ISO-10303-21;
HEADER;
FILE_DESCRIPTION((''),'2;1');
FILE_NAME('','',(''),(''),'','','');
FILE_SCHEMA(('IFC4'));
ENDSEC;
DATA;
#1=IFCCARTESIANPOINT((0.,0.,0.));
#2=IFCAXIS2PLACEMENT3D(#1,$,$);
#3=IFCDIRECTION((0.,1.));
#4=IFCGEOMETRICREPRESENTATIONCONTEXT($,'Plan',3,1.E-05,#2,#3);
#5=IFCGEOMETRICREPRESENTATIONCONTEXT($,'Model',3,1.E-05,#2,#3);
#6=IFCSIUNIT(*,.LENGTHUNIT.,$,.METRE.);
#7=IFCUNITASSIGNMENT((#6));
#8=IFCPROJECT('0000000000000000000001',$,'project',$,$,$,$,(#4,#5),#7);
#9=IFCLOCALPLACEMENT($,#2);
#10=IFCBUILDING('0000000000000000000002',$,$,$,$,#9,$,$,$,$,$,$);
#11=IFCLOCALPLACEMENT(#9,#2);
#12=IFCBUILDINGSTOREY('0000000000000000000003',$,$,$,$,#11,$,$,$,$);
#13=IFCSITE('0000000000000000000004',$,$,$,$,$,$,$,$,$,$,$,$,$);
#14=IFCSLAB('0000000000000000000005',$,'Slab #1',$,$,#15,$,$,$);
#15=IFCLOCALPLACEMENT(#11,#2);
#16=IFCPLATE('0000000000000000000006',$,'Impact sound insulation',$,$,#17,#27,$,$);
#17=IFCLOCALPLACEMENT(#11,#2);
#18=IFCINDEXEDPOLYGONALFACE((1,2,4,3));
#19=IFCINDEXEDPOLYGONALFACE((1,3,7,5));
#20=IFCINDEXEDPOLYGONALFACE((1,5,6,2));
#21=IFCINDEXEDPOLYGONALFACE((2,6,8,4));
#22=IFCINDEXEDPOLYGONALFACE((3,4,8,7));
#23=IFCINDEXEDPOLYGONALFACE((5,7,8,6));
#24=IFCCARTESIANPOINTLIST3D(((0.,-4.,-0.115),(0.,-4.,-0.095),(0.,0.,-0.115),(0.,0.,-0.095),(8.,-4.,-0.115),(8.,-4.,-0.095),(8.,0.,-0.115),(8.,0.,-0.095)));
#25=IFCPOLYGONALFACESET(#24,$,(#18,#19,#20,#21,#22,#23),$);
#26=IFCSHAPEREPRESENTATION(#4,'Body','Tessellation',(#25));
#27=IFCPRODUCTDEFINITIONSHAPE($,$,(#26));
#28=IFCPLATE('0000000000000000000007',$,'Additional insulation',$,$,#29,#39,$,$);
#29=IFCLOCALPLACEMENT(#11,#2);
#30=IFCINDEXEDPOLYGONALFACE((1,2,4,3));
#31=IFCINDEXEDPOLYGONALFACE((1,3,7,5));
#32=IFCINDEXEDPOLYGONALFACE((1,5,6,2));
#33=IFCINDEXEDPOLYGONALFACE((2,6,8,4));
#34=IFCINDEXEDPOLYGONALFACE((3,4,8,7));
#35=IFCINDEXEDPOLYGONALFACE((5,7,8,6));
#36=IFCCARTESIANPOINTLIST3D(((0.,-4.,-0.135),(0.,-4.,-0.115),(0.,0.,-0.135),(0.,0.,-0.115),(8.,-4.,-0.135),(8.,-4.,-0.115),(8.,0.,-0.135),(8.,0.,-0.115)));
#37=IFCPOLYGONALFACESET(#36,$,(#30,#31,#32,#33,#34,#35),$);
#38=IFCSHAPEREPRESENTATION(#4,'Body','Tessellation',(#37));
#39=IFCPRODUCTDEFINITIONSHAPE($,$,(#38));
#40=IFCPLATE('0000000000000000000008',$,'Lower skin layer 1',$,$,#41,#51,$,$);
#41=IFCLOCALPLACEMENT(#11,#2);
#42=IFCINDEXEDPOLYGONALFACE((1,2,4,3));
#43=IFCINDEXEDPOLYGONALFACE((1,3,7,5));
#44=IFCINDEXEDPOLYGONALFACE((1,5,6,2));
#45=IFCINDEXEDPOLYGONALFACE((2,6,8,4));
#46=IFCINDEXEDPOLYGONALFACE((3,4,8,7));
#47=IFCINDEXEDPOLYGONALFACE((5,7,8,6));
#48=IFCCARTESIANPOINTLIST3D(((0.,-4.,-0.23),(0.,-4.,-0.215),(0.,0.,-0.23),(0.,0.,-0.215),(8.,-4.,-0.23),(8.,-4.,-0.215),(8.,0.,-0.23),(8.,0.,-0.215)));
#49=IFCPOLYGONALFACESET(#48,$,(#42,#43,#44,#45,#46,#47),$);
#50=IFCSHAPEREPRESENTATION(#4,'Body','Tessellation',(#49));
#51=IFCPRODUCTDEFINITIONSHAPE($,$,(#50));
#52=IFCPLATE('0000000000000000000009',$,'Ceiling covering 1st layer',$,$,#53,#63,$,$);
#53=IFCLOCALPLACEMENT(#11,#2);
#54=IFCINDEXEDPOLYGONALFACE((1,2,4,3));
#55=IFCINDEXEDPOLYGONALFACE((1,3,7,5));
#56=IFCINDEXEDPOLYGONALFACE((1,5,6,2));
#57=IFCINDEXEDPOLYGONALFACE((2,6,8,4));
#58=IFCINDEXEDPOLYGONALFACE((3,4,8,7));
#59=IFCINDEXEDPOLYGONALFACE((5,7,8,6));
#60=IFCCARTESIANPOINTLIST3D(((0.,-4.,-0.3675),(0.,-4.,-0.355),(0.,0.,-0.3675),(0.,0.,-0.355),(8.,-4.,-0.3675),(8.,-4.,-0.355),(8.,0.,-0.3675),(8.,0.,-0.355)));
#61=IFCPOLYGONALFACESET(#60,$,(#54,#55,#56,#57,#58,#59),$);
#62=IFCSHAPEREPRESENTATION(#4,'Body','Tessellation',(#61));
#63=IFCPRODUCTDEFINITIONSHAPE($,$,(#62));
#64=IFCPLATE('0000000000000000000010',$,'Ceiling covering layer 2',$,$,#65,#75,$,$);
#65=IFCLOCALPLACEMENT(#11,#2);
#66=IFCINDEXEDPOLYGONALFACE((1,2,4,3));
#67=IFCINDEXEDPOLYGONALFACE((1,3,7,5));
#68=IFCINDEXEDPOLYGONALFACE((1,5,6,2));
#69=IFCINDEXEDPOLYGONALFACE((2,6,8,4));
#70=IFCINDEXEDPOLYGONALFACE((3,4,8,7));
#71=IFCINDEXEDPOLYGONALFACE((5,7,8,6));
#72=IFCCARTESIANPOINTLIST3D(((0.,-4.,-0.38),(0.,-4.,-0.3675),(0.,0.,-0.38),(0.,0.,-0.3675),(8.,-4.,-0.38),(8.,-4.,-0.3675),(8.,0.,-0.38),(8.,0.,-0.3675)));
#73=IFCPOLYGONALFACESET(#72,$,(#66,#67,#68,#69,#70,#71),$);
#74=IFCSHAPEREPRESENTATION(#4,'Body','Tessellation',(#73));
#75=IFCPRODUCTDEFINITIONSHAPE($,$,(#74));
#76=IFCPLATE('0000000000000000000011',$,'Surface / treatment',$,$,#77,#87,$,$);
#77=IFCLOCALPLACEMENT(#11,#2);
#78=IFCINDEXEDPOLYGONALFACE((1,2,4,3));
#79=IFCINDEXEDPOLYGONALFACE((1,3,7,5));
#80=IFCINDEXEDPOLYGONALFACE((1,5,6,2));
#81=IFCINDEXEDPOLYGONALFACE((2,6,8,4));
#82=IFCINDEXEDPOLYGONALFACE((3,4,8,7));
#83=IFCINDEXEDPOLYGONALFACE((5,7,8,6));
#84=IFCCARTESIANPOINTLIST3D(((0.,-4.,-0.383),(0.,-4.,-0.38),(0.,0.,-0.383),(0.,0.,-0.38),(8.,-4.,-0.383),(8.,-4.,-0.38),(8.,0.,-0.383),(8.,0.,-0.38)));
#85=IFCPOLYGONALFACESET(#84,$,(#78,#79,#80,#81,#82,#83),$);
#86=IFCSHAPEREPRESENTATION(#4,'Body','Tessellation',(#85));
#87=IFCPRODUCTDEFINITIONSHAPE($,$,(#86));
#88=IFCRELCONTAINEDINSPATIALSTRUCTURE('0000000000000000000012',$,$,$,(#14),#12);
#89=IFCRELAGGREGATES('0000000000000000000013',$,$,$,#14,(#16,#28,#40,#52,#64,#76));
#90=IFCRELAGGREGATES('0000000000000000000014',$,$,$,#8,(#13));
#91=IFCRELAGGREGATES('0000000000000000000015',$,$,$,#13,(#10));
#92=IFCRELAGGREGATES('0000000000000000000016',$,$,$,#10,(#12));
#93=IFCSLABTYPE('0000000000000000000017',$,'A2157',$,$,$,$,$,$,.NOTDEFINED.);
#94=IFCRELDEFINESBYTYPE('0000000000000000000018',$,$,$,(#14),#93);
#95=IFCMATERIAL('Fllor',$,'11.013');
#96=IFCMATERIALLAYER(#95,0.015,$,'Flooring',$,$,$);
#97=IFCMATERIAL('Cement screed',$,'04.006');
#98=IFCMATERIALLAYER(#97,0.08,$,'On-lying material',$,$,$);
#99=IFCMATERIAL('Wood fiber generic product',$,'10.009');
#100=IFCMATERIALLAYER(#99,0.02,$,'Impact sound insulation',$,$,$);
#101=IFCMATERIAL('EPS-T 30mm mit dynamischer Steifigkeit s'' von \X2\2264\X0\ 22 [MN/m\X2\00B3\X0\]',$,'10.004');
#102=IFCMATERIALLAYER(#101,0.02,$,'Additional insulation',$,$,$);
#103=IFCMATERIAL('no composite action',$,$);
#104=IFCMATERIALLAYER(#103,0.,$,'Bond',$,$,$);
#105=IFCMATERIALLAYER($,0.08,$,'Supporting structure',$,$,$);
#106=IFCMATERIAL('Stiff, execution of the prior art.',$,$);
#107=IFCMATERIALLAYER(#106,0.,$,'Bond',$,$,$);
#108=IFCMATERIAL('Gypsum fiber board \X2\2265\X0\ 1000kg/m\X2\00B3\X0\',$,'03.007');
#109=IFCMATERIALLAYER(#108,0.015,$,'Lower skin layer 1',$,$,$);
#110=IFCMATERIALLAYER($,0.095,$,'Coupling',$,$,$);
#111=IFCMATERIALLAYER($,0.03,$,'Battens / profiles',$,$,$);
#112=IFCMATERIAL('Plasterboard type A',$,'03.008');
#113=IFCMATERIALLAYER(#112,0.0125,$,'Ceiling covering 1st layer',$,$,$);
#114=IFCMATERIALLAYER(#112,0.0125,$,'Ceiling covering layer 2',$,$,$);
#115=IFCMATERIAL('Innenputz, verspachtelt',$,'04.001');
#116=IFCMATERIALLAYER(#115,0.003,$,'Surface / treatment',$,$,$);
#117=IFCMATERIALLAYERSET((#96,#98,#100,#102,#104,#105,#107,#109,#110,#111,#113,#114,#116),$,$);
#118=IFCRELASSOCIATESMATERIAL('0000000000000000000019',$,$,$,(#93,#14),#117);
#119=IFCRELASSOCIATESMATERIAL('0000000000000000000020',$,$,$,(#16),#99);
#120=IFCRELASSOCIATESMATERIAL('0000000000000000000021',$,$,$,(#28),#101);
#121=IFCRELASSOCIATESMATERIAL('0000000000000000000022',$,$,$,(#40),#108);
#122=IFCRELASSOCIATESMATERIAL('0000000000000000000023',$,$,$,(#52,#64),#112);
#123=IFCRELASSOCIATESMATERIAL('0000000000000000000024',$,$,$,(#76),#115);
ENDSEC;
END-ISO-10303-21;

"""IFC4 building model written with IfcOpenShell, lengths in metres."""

from ifc_helpers import new_model, si_unit, direction, frame, frame_2d, origin, place, context, project, spatial, rectangle, extrude, material, layer, layer_set, type_object, element, aggregate, save


model = new_model("IFC4")

# Units and contexts
plan_context = context("Plan", 3, precision=1e-05, world=origin(), true_north=direction((0.0, 1.0)))
model_context = context("Model", 3, precision=1e-05, world=origin(), true_north=direction((0.0, 1.0)))
ifc_project = project(units=[si_unit("LENGTHUNIT", "METRE")], contexts=[plan_context, model_context])

# Site, building, storey
site = spatial("IfcSite", under=ifc_project)
building_placement = place(None, origin())
building = spatial("IfcBuilding", under=site, at=building_placement)
storey_placement = place(building_placement, origin())
storey = spatial("IfcBuildingStorey", under=building, at=storey_placement)

# Slab, plates
ifc_material_1 = material(Name="Fllor", Category="11.013")
ifc_layer_1 = layer(ifc_material_1, 0.015, Name="Flooring")
ifc_material_2 = material(Name="Cement screed", Category="04.006")
ifc_layer_2 = layer(ifc_material_2, 0.08, Name="On-lying material")
ifc_material_3 = material(Name="Wood fiber generic product", Category="10.009")
ifc_layer_3 = layer(ifc_material_3, 0.02, Name="Impact sound insulation")
ifc_material_4 = material(Name="EPS-T 30mm mit dynamischer Steifigkeit s' von ≤ 22 [MN/m³]", Category="10.004")
ifc_layer_4 = layer(ifc_material_4, 0.02, Name="Additional insulation")
ifc_material_5 = material(Name="no composite action")
ifc_layer_5 = layer(ifc_material_5, 0.0, Name="Bond")
ifc_layer_6 = layer(None, 0.08, Name="Supporting structure")
ifc_material_6 = material(Name="Stiff, execution of the prior art.")
ifc_layer_7 = layer(ifc_material_6, 0.0, Name="Bond")
ifc_material_7 = material(Name="Gypsum fiber board ≥ 1000kg/m³", Category="03.007")
ifc_layer_8 = layer(ifc_material_7, 0.015, Name="Lower skin layer 1")
ifc_layer_9 = layer(None, 0.095, Name="Coupling")
ifc_layer_10 = layer(None, 0.03, Name="Battens / profiles")
ifc_material_8 = material(Name="Plasterboard type A", Category="03.008")
ifc_layer_11 = layer(ifc_material_8, 0.0125, Name="Ceiling covering 1st layer")
ifc_layer_12 = layer(ifc_material_8, 0.0125, Name="Ceiling covering layer 2")
ifc_material_9 = material(Name="Innenputz, verspachtelt", Category="04.001")
ifc_layer_13 = layer(ifc_material_9, 0.003, Name="Surface / treatment")
ifc_layer_set = layer_set([ifc_layer_1, ifc_layer_2, ifc_layer_3, ifc_layer_4, ifc_layer_5, ifc_layer_6, ifc_layer_7, ifc_layer_8, ifc_layer_9, ifc_layer_10, ifc_layer_11, ifc_layer_12, ifc_layer_13])
slab_type = type_object("IfcSlabType", Name="A2157", PredefinedType="NOTDEFINED", material=ifc_layer_set)
slab_placement = place(None, frame((0.0, 0.0, 0.0), z_axis=(0.0, 0.0, -1.0), x_axis=(1.0, 0.0, 0.0)))
slab = element("IfcSlab", 1, at=slab_placement, inside=storey, type_object=slab_type, material=ifc_layer_set, Name="Slab #1")
plate_1_placement = place(slab_placement, origin())
plate_1 = element("IfcPlate", 2, at=plate_1_placement, material=ifc_material_3, Name="Impact sound insulation", context=plan_context, shape_type="SweptSolid", body=[
    extrude(rectangle(XDim=8.0, YDim=4.0, at=frame_2d((4.0, 2.0), x_axis=(1.0, 0.0))), frame((0.0, 0.0, 0.095), z_axis=(0.0, 0.0, 1.0), x_axis=(1.0, 0.0, 0.0)), (0.0, 0.0, 1.0), 0.02),
])
plate_2_placement = place(slab_placement, origin())
plate_2 = element("IfcPlate", 3, at=plate_2_placement, material=ifc_material_4, Name="Additional insulation", context=plan_context, shape_type="SweptSolid", body=[
    extrude(rectangle(XDim=8.0, YDim=4.0, at=frame_2d((4.0, 2.0), x_axis=(1.0, 0.0))), frame((0.0, 0.0, 0.115), z_axis=(0.0, 0.0, 1.0), x_axis=(1.0, 0.0, 0.0)), (0.0, 0.0, 1.0), 0.02),
])
plate_3_placement = place(slab_placement, origin())
plate_3 = element("IfcPlate", 4, at=plate_3_placement, material=ifc_material_7, Name="Lower skin layer 1", context=plan_context, shape_type="SweptSolid", body=[
    extrude(rectangle(XDim=8.0, YDim=4.0, at=frame_2d((4.0, 2.0), x_axis=(1.0, 0.0))), frame((0.0, 0.0, 0.215), z_axis=(0.0, 0.0, 1.0), x_axis=(1.0, 0.0, 0.0)), (0.0, 0.0, 1.0), 0.015),
])
plate_4_placement = place(slab_placement, origin())
plate_4 = element("IfcPlate", 5, at=plate_4_placement, material=ifc_material_8, Name="Ceiling covering 1st layer", context=plan_context, shape_type="SweptSolid", body=[
    extrude(rectangle(XDim=8.0, YDim=4.0, at=frame_2d((4.0, 2.0), x_axis=(1.0, 0.0))), frame((0.0, 0.0, 0.355), z_axis=(0.0, 0.0, 1.0), x_axis=(1.0, 0.0, 0.0)), (0.0, 0.0, 1.0), 0.0125),
])
plate_5_placement = place(slab_placement, origin())
plate_5 = element("IfcPlate", 6, at=plate_5_placement, material=ifc_material_8, Name="Ceiling covering layer 2", context=plan_context, shape_type="SweptSolid", body=[
    extrude(rectangle(XDim=8.0, YDim=4.0, at=frame_2d((4.0, 2.0), x_axis=(1.0, 0.0))), frame((0.0, 0.0, 0.3675), z_axis=(0.0, 0.0, 1.0), x_axis=(1.0, 0.0, 0.0)), (0.0, 0.0, 1.0), 0.0125),
])
plate_6_placement = place(slab_placement, origin())
plate_6 = element("IfcPlate", 7, at=plate_6_placement, material=ifc_material_9, Name="Surface / treatment", context=plan_context, shape_type="SweptSolid", body=[
    extrude(rectangle(XDim=8.0, YDim=4.0, at=frame_2d((4.0, 2.0), x_axis=(1.0, 0.0))), frame((0.0, 0.0, 0.38), z_axis=(0.0, 0.0, 1.0), x_axis=(1.0, 0.0, 0.0)), (0.0, 0.0, 1.0), 0.003),
])
aggregate(slab, [plate_1, plate_2, plate_3, plate_4, plate_5, plate_6])

save(model, "model.ifc")
